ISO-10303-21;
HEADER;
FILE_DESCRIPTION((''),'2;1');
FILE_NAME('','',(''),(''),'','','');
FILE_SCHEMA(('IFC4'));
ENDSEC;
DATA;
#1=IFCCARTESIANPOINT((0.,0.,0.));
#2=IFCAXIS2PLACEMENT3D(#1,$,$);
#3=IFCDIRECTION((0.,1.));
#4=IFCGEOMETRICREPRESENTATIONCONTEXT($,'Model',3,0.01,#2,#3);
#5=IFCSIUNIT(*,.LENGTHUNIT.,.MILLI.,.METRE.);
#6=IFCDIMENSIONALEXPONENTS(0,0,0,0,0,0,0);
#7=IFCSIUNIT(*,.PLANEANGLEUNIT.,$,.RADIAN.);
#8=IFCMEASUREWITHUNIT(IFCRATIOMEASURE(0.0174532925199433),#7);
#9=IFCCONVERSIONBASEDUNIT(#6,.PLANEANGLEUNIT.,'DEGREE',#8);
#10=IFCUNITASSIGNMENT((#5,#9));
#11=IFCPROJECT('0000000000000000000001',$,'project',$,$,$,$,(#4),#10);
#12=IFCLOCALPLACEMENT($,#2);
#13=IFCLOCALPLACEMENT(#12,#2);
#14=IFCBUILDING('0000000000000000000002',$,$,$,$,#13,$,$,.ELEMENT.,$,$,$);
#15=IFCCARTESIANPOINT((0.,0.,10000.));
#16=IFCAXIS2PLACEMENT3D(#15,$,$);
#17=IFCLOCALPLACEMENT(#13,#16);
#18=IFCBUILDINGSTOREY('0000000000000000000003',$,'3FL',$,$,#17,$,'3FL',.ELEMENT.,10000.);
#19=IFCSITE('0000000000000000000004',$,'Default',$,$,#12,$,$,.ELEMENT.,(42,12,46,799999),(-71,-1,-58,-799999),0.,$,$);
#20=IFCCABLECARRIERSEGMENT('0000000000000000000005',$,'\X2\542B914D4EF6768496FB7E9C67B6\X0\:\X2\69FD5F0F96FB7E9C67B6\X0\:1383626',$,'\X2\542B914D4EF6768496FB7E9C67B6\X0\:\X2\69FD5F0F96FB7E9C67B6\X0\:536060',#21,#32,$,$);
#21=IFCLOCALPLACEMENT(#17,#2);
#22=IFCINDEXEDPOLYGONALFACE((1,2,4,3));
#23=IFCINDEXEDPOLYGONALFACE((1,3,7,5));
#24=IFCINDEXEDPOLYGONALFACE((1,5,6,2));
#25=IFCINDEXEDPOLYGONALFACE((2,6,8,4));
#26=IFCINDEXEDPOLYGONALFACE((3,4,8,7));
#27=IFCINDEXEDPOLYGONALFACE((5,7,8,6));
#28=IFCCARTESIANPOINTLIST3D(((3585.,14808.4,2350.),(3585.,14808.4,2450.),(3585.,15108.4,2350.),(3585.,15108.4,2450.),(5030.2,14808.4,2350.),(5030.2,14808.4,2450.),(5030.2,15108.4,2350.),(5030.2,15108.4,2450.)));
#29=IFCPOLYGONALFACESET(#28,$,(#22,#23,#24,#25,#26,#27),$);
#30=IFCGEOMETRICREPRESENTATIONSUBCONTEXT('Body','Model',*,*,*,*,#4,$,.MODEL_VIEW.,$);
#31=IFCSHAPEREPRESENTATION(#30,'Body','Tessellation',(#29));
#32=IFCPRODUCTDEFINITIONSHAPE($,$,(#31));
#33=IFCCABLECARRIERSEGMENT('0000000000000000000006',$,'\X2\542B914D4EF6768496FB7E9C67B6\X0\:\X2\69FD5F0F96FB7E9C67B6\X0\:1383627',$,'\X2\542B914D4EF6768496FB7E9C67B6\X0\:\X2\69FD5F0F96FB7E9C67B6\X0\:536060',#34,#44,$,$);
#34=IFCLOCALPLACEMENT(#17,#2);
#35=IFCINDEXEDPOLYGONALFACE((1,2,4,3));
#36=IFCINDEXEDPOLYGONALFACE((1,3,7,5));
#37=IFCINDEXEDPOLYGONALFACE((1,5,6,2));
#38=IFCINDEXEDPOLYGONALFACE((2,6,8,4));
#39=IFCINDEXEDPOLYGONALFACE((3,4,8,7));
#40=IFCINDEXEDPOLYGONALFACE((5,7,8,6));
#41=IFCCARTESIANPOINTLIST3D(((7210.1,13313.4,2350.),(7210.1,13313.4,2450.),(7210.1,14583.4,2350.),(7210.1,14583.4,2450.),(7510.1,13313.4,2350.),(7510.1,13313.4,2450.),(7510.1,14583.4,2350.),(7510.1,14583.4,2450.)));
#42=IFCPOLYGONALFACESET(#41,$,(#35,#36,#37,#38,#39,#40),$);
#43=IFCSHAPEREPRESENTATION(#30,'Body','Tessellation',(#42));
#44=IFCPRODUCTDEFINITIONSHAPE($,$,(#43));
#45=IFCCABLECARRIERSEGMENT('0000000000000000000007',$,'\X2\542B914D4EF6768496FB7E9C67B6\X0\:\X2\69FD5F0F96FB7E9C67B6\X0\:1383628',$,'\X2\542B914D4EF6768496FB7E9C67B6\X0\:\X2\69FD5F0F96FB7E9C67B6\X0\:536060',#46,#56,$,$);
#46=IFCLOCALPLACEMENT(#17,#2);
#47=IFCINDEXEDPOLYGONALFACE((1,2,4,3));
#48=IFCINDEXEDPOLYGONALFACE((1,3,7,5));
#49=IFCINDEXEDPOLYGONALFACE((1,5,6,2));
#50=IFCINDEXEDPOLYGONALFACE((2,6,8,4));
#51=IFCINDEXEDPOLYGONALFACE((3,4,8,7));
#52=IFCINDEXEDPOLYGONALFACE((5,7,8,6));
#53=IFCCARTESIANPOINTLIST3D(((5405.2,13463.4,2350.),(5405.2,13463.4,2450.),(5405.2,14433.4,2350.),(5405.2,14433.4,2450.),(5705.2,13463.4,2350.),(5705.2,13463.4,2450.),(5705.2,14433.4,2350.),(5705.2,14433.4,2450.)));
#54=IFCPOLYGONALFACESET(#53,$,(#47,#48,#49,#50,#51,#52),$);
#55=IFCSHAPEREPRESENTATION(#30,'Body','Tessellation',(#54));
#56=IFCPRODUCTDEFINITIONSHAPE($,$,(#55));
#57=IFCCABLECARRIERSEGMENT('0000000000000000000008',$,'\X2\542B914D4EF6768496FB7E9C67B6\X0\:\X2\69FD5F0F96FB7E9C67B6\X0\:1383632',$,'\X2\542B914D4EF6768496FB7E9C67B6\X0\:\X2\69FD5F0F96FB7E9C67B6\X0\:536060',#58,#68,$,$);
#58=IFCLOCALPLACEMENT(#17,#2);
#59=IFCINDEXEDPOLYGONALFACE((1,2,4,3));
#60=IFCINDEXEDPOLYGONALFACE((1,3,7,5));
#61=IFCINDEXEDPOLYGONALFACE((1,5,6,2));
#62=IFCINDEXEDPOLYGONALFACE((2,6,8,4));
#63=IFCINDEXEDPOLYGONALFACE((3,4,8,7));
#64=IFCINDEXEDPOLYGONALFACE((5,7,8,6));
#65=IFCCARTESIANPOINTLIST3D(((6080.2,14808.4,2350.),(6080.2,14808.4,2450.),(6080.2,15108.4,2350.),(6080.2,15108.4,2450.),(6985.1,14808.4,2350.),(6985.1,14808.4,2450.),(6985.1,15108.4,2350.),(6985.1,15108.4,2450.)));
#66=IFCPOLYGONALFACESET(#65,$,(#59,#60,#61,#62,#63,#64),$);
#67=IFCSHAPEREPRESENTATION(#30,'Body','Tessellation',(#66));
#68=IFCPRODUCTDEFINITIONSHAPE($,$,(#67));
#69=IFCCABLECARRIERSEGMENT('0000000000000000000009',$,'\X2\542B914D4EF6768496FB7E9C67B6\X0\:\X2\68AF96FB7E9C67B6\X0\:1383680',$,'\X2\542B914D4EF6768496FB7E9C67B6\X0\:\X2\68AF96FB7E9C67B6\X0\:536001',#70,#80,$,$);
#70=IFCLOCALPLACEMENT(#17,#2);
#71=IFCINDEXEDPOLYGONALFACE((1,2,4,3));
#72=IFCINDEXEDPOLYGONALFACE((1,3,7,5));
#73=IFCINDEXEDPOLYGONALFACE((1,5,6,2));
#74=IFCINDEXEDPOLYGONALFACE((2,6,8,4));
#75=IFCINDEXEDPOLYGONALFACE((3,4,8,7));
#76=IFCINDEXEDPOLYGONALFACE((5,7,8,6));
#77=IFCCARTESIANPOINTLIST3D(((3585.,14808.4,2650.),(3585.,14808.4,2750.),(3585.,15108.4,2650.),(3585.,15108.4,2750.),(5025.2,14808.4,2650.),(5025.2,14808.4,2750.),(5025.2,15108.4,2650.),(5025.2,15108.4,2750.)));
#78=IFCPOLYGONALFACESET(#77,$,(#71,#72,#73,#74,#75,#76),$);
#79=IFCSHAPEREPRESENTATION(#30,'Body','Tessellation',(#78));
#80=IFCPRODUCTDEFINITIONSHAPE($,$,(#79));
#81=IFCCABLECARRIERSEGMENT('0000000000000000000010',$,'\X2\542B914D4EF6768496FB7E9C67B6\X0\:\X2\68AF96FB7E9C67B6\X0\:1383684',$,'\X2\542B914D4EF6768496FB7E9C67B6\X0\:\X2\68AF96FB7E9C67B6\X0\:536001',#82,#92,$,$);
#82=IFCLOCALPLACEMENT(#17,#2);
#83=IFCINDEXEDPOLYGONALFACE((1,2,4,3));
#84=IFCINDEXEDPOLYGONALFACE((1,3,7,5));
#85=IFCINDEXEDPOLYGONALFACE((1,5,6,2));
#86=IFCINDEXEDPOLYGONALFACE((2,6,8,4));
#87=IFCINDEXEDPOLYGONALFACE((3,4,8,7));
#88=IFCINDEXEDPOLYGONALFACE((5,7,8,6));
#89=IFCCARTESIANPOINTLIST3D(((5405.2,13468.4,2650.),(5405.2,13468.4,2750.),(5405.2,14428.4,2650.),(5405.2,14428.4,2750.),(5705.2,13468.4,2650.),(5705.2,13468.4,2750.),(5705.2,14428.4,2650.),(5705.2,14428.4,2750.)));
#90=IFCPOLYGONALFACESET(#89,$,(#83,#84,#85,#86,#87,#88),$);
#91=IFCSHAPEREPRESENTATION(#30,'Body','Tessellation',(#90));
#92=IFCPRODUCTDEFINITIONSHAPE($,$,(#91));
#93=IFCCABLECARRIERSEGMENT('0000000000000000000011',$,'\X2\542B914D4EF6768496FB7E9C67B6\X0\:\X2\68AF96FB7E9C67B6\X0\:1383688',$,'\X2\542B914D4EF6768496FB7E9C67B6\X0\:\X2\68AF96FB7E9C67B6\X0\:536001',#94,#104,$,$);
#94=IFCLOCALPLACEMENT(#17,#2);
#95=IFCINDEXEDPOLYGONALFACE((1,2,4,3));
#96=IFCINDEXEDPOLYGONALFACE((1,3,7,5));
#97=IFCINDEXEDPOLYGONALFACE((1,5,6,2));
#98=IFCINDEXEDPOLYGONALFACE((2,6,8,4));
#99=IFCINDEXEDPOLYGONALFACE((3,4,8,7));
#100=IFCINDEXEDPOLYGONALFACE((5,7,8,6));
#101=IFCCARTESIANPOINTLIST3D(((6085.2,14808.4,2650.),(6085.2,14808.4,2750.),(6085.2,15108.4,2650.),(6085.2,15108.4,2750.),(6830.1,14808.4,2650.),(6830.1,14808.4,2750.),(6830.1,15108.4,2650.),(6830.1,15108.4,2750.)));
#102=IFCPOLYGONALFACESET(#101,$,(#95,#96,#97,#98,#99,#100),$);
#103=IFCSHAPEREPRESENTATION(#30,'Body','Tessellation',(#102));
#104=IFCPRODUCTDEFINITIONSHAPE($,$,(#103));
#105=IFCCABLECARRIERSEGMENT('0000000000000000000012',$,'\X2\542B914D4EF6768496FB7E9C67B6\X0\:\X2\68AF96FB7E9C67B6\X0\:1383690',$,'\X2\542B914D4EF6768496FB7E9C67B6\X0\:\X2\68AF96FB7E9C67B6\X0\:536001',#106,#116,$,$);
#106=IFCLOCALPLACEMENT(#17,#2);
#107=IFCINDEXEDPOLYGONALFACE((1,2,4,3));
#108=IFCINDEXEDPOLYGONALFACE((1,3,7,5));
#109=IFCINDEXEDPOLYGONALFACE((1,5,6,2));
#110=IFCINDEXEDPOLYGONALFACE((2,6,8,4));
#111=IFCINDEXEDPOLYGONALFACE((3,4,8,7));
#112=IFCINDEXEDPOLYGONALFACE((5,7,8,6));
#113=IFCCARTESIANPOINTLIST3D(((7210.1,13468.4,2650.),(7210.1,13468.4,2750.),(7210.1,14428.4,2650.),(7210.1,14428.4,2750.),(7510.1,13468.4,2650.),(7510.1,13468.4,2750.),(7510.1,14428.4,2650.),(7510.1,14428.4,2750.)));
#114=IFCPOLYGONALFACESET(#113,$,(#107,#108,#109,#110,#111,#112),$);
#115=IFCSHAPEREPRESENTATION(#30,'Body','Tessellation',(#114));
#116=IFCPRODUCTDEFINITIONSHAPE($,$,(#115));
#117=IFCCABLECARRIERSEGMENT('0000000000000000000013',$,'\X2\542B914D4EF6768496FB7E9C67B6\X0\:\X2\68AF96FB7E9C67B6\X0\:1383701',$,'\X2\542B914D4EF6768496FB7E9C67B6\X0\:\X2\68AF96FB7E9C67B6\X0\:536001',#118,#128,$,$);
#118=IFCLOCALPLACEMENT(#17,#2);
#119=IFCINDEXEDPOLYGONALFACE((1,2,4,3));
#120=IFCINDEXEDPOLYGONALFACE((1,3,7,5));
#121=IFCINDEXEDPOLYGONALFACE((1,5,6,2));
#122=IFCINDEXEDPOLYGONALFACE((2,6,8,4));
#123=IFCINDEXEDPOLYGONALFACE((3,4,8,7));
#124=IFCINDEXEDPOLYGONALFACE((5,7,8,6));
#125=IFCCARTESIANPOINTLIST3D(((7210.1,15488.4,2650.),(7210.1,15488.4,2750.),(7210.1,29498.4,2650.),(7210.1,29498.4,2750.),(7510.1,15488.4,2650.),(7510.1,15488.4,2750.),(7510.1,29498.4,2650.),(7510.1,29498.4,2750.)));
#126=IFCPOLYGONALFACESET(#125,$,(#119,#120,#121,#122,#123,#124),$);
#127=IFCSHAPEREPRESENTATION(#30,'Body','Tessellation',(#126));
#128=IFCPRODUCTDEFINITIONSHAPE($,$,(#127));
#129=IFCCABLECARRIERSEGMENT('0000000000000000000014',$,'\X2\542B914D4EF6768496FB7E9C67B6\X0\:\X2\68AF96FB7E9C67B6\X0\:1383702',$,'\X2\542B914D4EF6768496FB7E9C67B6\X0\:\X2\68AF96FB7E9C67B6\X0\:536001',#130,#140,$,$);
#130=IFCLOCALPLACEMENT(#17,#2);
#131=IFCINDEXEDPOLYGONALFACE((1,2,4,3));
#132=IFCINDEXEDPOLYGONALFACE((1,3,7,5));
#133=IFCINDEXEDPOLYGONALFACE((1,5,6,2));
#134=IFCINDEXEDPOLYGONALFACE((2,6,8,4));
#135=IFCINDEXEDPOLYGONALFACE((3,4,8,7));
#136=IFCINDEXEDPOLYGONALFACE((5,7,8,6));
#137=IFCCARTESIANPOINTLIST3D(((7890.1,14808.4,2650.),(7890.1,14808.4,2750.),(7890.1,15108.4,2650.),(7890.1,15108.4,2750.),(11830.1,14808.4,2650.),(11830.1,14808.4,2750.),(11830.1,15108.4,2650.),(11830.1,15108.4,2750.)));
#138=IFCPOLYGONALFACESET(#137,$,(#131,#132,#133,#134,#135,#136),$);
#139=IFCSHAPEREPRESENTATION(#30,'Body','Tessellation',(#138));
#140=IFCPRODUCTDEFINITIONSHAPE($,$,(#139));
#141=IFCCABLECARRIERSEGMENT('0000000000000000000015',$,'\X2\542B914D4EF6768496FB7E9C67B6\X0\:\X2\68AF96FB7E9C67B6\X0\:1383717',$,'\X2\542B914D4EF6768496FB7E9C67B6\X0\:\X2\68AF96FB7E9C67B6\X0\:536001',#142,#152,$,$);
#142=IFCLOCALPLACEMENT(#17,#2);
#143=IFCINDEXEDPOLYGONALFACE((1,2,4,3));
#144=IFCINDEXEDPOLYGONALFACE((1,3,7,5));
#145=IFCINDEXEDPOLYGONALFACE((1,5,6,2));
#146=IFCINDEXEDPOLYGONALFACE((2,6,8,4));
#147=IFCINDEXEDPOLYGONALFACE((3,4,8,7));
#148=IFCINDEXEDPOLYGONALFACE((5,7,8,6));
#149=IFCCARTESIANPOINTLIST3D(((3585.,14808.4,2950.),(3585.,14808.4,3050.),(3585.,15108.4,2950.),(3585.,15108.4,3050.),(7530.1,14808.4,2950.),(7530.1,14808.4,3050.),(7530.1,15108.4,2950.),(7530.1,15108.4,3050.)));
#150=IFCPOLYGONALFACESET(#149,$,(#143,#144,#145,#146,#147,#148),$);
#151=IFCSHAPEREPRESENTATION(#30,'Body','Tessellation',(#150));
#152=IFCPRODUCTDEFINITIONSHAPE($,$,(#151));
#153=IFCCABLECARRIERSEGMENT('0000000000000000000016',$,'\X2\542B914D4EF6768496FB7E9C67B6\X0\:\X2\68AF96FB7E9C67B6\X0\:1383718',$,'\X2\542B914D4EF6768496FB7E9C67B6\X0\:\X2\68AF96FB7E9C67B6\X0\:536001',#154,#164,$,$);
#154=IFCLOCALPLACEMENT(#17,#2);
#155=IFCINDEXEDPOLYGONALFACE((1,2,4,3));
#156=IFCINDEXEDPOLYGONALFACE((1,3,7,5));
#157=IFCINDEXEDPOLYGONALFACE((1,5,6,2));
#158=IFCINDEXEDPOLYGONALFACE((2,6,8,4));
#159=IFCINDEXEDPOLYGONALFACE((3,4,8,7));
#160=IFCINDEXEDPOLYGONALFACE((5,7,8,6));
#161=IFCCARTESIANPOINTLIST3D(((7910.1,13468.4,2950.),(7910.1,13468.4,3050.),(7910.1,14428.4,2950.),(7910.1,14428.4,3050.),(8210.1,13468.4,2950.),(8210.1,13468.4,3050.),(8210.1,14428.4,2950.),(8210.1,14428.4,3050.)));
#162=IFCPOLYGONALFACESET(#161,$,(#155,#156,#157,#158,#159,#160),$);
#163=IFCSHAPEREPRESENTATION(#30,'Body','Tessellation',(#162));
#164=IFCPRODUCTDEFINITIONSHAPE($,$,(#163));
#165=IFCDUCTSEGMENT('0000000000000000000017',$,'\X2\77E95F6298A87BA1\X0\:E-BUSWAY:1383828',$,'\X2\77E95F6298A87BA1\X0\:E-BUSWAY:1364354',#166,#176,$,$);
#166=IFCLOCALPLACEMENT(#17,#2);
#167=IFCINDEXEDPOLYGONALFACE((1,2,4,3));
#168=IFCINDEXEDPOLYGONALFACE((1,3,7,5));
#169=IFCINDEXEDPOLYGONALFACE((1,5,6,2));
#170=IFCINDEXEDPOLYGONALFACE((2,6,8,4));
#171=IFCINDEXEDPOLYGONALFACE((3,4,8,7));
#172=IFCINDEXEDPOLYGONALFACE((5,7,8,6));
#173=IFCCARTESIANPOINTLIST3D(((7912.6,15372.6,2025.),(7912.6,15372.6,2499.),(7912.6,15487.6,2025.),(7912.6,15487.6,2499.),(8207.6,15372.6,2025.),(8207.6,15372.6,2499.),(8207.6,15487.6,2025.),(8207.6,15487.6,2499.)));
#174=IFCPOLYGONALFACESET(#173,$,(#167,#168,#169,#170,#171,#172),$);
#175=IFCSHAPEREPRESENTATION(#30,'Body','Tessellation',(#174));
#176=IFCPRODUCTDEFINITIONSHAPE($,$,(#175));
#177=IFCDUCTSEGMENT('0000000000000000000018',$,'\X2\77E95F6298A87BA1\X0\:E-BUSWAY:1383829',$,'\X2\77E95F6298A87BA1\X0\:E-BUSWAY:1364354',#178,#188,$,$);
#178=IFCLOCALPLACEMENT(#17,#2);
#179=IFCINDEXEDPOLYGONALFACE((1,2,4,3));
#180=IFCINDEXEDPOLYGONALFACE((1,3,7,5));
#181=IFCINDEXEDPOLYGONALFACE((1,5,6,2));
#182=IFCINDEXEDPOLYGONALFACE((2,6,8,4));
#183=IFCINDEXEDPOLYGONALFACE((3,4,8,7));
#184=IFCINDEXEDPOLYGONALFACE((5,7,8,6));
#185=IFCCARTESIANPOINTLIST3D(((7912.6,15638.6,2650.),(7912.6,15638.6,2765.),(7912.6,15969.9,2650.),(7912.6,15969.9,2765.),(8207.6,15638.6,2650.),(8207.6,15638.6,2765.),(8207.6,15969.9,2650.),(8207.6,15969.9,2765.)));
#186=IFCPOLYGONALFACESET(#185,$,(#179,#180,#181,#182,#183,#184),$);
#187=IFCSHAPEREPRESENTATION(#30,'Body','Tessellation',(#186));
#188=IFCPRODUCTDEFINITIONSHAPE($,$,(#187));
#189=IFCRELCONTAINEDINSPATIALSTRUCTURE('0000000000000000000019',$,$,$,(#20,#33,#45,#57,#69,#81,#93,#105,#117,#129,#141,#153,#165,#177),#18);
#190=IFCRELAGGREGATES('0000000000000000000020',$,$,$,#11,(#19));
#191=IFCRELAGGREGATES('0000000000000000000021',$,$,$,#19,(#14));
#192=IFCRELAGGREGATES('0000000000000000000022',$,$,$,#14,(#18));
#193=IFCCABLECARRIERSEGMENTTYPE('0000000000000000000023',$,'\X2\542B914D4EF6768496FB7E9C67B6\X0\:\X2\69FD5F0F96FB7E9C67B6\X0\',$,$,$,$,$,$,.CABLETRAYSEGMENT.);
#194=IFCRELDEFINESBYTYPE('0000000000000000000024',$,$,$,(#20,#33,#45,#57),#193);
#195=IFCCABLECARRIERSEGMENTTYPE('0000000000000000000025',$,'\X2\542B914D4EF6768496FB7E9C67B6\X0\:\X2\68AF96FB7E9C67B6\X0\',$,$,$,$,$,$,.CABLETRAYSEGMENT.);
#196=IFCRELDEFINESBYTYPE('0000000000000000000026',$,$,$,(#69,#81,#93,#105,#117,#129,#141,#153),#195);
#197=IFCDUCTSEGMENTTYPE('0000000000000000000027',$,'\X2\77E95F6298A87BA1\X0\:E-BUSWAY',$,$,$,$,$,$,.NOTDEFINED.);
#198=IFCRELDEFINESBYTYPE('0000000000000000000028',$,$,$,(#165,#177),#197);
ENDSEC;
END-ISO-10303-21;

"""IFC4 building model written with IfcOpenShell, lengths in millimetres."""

from ifc_helpers import new_model, entity, si_unit, converted_unit, direction, frame, frame_2d, origin, origin_2d_with_axis, place, context, subcontext, project, spatial, rectangle, extrude, type_object, element, save


model = new_model("IFC4")

# Units and contexts
model_context = context("Model", 3, precision=0.01, world=origin(), true_north=direction((0.0, 1.0)))
body_context = subcontext(model_context, "Body", "Model", "MODEL_VIEW")
ifc_project = project(units=[si_unit("LENGTHUNIT", "METRE", prefix="MILLI"), converted_unit("PLANEANGLEUNIT", "DEGREE", entity("IfcRatioMeasure", 0.0174532925199433), si_unit("PLANEANGLEUNIT", "RADIAN"), dimensions=[0, 0, 0, 0, 0, 0, 0])], contexts=[model_context])

# Site, building, storey
site_placement = place(None, origin())
site = spatial("IfcSite", under=ifc_project, at=site_placement, Name="Default", CompositionType="ELEMENT", RefLatitude=(42, 12, 46, 799999), RefLongitude=(-71, -1, -58, -799999), RefElevation=0.0)
building_placement = place(site_placement, origin())
building = spatial("IfcBuilding", under=site, at=building_placement, CompositionType="ELEMENT")
storey_placement = place(building_placement, frame((0.0, 0.0, 10000.0)))
storey = spatial("IfcBuildingStorey", under=building, at=storey_placement, Name="3FL", LongName="3FL", CompositionType="ELEMENT", Elevation=10000.0)

# Cable carrier segments
cable_carrier_segment_type_1 = type_object("IfcCableCarrierSegmentType", Name="含配件的電纜架:槽式電纜架", PredefinedType="CABLETRAYSEGMENT")
cable_carrier_segment_1_placement = place(storey_placement, frame((3585.0, 14808.4, 2350.0)))
element("IfcCableCarrierSegment", 1, at=cable_carrier_segment_1_placement, inside=storey, type_object=cable_carrier_segment_type_1, Name="含配件的電纜架:槽式電纜架:1383626", ObjectType="含配件的電纜架:槽式電纜架:536060", context=body_context, shape_type="SweptSolid", body=[
    extrude(rectangle(XDim=1445.2, YDim=300.0, at=frame_2d((0.0, 0.0), x_axis=(1.0, 0.0))), frame((722.6, 150.0, 0.0), z_axis=(0.0, 0.0, 1.0), x_axis=(-1.0, 0.0, 0.0)), (0.0, 0.0, 1.0), 100.0),
])
cable_carrier_segment_2_placement = place(storey_placement, frame((7210.1, 13313.4, 2350.0)))
element("IfcCableCarrierSegment", 2, at=cable_carrier_segment_2_placement, inside=storey, type_object=cable_carrier_segment_type_1, Name="含配件的電纜架:槽式電纜架:1383627", ObjectType="含配件的電纜架:槽式電纜架:536060", context=body_context, shape_type="SweptSolid", body=[
    extrude(rectangle(XDim=1270.0, YDim=300.0, at=frame_2d((0.0, 0.0), x_axis=(1.0, 0.0))), frame((150.0, 635.0, 0.0), z_axis=(0.0, 0.0, 1.0), x_axis=(0.0, -1.0, 0.0)), (0.0, 0.0, 1.0), 100.0),
])
cable_carrier_segment_3_placement = place(storey_placement, frame((5405.2, 13463.4, 2350.0)))
element("IfcCableCarrierSegment", 3, at=cable_carrier_segment_3_placement, inside=storey, type_object=cable_carrier_segment_type_1, Name="含配件的電纜架:槽式電纜架:1383628", ObjectType="含配件的電纜架:槽式電纜架:536060", context=body_context, shape_type="SweptSolid", body=[
    extrude(rectangle(XDim=970.0, YDim=300.0, at=frame_2d((0.0, 0.0), x_axis=(1.0, 0.0))), frame((150.0, 485.0, 0.0), z_axis=(0.0, 0.0, 1.0), x_axis=(0.0, -1.0, 0.0)), (0.0, 0.0, 1.0), 100.0),
])
cable_carrier_segment_4_placement = place(storey_placement, frame((6080.2, 14808.4, 2350.0)))
element("IfcCableCarrierSegment", 4, at=cable_carrier_segment_4_placement, inside=storey, type_object=cable_carrier_segment_type_1, Name="含配件的電纜架:槽式電纜架:1383632", ObjectType="含配件的電纜架:槽式電纜架:536060", context=body_context, shape_type="SweptSolid", body=[
    extrude(rectangle(XDim=904.9, YDim=300.0, at=frame_2d((0.0, 0.0), x_axis=(1.0, 0.0))), frame((452.4, 150.0, 0.0), z_axis=(0.0, 0.0, 1.0), x_axis=(-1.0, 0.0, 0.0)), (0.0, 0.0, 1.0), 100.0),
])
cable_carrier_segment_type_2 = type_object("IfcCableCarrierSegmentType", Name="含配件的電纜架:梯電纜架", PredefinedType="CABLETRAYSEGMENT")
cable_carrier_segment_5_placement = place(storey_placement, frame((3585.0, 14808.4, 2650.0)))
element("IfcCableCarrierSegment", 5, at=cable_carrier_segment_5_placement, inside=storey, type_object=cable_carrier_segment_type_2, Name="含配件的電纜架:梯電纜架:1383680", ObjectType="含配件的電纜架:梯電纜架:536001", context=body_context, shape_type="SweptSolid", body=[
    extrude(rectangle(XDim=1440.2, YDim=300.0, at=frame_2d((0.0, 0.0), x_axis=(1.0, 0.0))), frame((720.1, 150.0, 0.0), z_axis=(0.0, 0.0, 1.0), x_axis=(-1.0, 0.0, 0.0)), (0.0, 0.0, 1.0), 100.0),
])
cable_carrier_segment_6_placement = place(storey_placement, frame((5405.2, 13468.4, 2650.0)))
element("IfcCableCarrierSegment", 6, at=cable_carrier_segment_6_placement, inside=storey, type_object=cable_carrier_segment_type_2, Name="含配件的電纜架:梯電纜架:1383684", ObjectType="含配件的電纜架:梯電纜架:536001", context=body_context, shape_type="SweptSolid", body=[
    extrude(rectangle(XDim=960.0, YDim=300.0, at=frame_2d((0.0, 0.0), x_axis=(1.0, 0.0))), frame((150.0, 480.0, 0.0), z_axis=(0.0, 0.0, 1.0), x_axis=(0.0, -1.0, 0.0)), (0.0, 0.0, 1.0), 100.0),
])
cable_carrier_segment_7_placement = place(storey_placement, frame((6085.2, 14808.4, 2650.0)))
element("IfcCableCarrierSegment", 7, at=cable_carrier_segment_7_placement, inside=storey, type_object=cable_carrier_segment_type_2, Name="含配件的電纜架:梯電纜架:1383688", ObjectType="含配件的電纜架:梯電纜架:536001", context=body_context, shape_type="SweptSolid", body=[
    extrude(rectangle(XDim=744.9, YDim=300.0, at=origin_2d_with_axis()), frame((372.4, 150.0, 0.0), z_axis=(0.0, 0.0, 1.0), x_axis=(-1.0, 0.0, 0.0)), (0.0, 0.0, 1.0), 100.0),
])
cable_carrier_segment_8_placement = place(storey_placement, frame((7210.1, 13468.4, 2650.0)))
element("IfcCableCarrierSegment", 8, at=cable_carrier_segment_8_placement, inside=storey, type_object=cable_carrier_segment_type_2, Name="含配件的電纜架:梯電纜架:1383690", ObjectType="含配件的電纜架:梯電纜架:536001", context=body_context, shape_type="SweptSolid", body=[
    extrude(rectangle(XDim=960.0, YDim=300.0, at=origin_2d_with_axis()), frame((150.0, 480.0, 0.0), z_axis=(0.0, 0.0, 1.0), x_axis=(0.0, -1.0, 0.0)), (0.0, 0.0, 1.0), 100.0),
])
cable_carrier_segment_9_placement = place(storey_placement, frame((7210.1, 15488.4, 2650.0)))
element("IfcCableCarrierSegment", 9, at=cable_carrier_segment_9_placement, inside=storey, type_object=cable_carrier_segment_type_2, Name="含配件的電纜架:梯電纜架:1383701", ObjectType="含配件的電纜架:梯電纜架:536001", context=body_context, shape_type="SweptSolid", body=[
    extrude(rectangle(XDim=14010.0, YDim=300.0, at=frame_2d((0.0, 0.0), x_axis=(1.0, 0.0))), frame((150.0, 7005.0, 0.0), z_axis=(0.0, 0.0, 1.0), x_axis=(0.0, -1.0, 0.0)), (0.0, 0.0, 1.0), 100.0),
])
cable_carrier_segment_10_placement = place(storey_placement, frame((7890.1, 14808.4, 2650.0)))
element("IfcCableCarrierSegment", 10, at=cable_carrier_segment_10_placement, inside=storey, type_object=cable_carrier_segment_type_2, Name="含配件的電纜架:梯電纜架:1383702", ObjectType="含配件的電纜架:梯電纜架:536001", context=body_context, shape_type="SweptSolid", body=[
    extrude(rectangle(XDim=3940.0, YDim=300.0, at=frame_2d((0.0, 0.0), x_axis=(1.0, 0.0))), frame((1970.0, 150.0, 0.0), z_axis=(0.0, 0.0, 1.0), x_axis=(-1.0, 0.0, 0.0)), (0.0, 0.0, 1.0), 100.0),
])
cable_carrier_segment_11_placement = place(storey_placement, frame((3585.0, 14808.4, 2950.0)))
element("IfcCableCarrierSegment", 11, at=cable_carrier_segment_11_placement, inside=storey, type_object=cable_carrier_segment_type_2, Name="含配件的電纜架:梯電纜架:1383717", ObjectType="含配件的電纜架:梯電纜架:536001", context=body_context, shape_type="SweptSolid", body=[
    extrude(rectangle(XDim=3945.1, YDim=300.0, at=frame_2d((0.0, 0.0), x_axis=(1.0, 0.0))), frame((1972.5, 150.0, 0.0), z_axis=(0.0, 0.0, 1.0), x_axis=(-1.0, 0.0, 0.0)), (0.0, 0.0, 1.0), 100.0),
])
cable_carrier_segment_12_placement = place(storey_placement, frame((7910.1, 13468.4, 2950.0)))
element("IfcCableCarrierSegment", 12, at=cable_carrier_segment_12_placement, inside=storey, type_object=cable_carrier_segment_type_2, Name="含配件的電纜架:梯電纜架:1383718", ObjectType="含配件的電纜架:梯電纜架:536001", context=body_context, shape_type="SweptSolid", body=[
    extrude(rectangle(XDim=960.0, YDim=300.0, at=frame_2d((0.0, 0.0), x_axis=(1.0, 0.0))), frame((150.0, 480.0, 0.0), z_axis=(0.0, 0.0, 1.0), x_axis=(0.0, -1.0, 0.0)), (0.0, 0.0, 1.0), 100.0),
])

# Duct segments
duct_segment_type = type_object("IfcDuctSegmentType", Name="矩形風管:E-BUSWAY", PredefinedType="NOTDEFINED")
duct_segment_1_placement = place(storey_placement, frame((7912.6, 15372.6, 2025.0)))
element("IfcDuctSegment", 13, at=duct_segment_1_placement, inside=storey, type_object=duct_segment_type, Name="矩形風管:E-BUSWAY:1383828", ObjectType="矩形風管:E-BUSWAY:1364354", context=body_context, shape_type="SweptSolid", body=[
    extrude(rectangle(XDim=115.0, YDim=295.0, at=frame_2d((0.0, 0.0), x_axis=(1.0, 0.0))), frame((147.5, 57.5, 0.0), z_axis=(0.0, 0.0, 1.0), x_axis=(0.0, -1.0, 0.0)), (0.0, 0.0, 1.0), 474.0),
])
duct_segment_2_placement = place(storey_placement, frame((7912.6, 15638.6, 2650.0)))
element("IfcDuctSegment", 14, at=duct_segment_2_placement, inside=storey, type_object=duct_segment_type, Name="矩形風管:E-BUSWAY:1383829", ObjectType="矩形風管:E-BUSWAY:1364354", context=body_context, shape_type="SweptSolid", body=[
    extrude(rectangle(XDim=331.3, YDim=295.0, at=frame_2d((0.0, 0.0), x_axis=(1.0, 0.0))), frame((147.5, 165.7, 0.0), z_axis=(0.0, 0.0, 1.0), x_axis=(0.0, 1.0, 0.0)), (0.0, 0.0, 1.0), 115.0),
])

save(model, "model.ifc")
